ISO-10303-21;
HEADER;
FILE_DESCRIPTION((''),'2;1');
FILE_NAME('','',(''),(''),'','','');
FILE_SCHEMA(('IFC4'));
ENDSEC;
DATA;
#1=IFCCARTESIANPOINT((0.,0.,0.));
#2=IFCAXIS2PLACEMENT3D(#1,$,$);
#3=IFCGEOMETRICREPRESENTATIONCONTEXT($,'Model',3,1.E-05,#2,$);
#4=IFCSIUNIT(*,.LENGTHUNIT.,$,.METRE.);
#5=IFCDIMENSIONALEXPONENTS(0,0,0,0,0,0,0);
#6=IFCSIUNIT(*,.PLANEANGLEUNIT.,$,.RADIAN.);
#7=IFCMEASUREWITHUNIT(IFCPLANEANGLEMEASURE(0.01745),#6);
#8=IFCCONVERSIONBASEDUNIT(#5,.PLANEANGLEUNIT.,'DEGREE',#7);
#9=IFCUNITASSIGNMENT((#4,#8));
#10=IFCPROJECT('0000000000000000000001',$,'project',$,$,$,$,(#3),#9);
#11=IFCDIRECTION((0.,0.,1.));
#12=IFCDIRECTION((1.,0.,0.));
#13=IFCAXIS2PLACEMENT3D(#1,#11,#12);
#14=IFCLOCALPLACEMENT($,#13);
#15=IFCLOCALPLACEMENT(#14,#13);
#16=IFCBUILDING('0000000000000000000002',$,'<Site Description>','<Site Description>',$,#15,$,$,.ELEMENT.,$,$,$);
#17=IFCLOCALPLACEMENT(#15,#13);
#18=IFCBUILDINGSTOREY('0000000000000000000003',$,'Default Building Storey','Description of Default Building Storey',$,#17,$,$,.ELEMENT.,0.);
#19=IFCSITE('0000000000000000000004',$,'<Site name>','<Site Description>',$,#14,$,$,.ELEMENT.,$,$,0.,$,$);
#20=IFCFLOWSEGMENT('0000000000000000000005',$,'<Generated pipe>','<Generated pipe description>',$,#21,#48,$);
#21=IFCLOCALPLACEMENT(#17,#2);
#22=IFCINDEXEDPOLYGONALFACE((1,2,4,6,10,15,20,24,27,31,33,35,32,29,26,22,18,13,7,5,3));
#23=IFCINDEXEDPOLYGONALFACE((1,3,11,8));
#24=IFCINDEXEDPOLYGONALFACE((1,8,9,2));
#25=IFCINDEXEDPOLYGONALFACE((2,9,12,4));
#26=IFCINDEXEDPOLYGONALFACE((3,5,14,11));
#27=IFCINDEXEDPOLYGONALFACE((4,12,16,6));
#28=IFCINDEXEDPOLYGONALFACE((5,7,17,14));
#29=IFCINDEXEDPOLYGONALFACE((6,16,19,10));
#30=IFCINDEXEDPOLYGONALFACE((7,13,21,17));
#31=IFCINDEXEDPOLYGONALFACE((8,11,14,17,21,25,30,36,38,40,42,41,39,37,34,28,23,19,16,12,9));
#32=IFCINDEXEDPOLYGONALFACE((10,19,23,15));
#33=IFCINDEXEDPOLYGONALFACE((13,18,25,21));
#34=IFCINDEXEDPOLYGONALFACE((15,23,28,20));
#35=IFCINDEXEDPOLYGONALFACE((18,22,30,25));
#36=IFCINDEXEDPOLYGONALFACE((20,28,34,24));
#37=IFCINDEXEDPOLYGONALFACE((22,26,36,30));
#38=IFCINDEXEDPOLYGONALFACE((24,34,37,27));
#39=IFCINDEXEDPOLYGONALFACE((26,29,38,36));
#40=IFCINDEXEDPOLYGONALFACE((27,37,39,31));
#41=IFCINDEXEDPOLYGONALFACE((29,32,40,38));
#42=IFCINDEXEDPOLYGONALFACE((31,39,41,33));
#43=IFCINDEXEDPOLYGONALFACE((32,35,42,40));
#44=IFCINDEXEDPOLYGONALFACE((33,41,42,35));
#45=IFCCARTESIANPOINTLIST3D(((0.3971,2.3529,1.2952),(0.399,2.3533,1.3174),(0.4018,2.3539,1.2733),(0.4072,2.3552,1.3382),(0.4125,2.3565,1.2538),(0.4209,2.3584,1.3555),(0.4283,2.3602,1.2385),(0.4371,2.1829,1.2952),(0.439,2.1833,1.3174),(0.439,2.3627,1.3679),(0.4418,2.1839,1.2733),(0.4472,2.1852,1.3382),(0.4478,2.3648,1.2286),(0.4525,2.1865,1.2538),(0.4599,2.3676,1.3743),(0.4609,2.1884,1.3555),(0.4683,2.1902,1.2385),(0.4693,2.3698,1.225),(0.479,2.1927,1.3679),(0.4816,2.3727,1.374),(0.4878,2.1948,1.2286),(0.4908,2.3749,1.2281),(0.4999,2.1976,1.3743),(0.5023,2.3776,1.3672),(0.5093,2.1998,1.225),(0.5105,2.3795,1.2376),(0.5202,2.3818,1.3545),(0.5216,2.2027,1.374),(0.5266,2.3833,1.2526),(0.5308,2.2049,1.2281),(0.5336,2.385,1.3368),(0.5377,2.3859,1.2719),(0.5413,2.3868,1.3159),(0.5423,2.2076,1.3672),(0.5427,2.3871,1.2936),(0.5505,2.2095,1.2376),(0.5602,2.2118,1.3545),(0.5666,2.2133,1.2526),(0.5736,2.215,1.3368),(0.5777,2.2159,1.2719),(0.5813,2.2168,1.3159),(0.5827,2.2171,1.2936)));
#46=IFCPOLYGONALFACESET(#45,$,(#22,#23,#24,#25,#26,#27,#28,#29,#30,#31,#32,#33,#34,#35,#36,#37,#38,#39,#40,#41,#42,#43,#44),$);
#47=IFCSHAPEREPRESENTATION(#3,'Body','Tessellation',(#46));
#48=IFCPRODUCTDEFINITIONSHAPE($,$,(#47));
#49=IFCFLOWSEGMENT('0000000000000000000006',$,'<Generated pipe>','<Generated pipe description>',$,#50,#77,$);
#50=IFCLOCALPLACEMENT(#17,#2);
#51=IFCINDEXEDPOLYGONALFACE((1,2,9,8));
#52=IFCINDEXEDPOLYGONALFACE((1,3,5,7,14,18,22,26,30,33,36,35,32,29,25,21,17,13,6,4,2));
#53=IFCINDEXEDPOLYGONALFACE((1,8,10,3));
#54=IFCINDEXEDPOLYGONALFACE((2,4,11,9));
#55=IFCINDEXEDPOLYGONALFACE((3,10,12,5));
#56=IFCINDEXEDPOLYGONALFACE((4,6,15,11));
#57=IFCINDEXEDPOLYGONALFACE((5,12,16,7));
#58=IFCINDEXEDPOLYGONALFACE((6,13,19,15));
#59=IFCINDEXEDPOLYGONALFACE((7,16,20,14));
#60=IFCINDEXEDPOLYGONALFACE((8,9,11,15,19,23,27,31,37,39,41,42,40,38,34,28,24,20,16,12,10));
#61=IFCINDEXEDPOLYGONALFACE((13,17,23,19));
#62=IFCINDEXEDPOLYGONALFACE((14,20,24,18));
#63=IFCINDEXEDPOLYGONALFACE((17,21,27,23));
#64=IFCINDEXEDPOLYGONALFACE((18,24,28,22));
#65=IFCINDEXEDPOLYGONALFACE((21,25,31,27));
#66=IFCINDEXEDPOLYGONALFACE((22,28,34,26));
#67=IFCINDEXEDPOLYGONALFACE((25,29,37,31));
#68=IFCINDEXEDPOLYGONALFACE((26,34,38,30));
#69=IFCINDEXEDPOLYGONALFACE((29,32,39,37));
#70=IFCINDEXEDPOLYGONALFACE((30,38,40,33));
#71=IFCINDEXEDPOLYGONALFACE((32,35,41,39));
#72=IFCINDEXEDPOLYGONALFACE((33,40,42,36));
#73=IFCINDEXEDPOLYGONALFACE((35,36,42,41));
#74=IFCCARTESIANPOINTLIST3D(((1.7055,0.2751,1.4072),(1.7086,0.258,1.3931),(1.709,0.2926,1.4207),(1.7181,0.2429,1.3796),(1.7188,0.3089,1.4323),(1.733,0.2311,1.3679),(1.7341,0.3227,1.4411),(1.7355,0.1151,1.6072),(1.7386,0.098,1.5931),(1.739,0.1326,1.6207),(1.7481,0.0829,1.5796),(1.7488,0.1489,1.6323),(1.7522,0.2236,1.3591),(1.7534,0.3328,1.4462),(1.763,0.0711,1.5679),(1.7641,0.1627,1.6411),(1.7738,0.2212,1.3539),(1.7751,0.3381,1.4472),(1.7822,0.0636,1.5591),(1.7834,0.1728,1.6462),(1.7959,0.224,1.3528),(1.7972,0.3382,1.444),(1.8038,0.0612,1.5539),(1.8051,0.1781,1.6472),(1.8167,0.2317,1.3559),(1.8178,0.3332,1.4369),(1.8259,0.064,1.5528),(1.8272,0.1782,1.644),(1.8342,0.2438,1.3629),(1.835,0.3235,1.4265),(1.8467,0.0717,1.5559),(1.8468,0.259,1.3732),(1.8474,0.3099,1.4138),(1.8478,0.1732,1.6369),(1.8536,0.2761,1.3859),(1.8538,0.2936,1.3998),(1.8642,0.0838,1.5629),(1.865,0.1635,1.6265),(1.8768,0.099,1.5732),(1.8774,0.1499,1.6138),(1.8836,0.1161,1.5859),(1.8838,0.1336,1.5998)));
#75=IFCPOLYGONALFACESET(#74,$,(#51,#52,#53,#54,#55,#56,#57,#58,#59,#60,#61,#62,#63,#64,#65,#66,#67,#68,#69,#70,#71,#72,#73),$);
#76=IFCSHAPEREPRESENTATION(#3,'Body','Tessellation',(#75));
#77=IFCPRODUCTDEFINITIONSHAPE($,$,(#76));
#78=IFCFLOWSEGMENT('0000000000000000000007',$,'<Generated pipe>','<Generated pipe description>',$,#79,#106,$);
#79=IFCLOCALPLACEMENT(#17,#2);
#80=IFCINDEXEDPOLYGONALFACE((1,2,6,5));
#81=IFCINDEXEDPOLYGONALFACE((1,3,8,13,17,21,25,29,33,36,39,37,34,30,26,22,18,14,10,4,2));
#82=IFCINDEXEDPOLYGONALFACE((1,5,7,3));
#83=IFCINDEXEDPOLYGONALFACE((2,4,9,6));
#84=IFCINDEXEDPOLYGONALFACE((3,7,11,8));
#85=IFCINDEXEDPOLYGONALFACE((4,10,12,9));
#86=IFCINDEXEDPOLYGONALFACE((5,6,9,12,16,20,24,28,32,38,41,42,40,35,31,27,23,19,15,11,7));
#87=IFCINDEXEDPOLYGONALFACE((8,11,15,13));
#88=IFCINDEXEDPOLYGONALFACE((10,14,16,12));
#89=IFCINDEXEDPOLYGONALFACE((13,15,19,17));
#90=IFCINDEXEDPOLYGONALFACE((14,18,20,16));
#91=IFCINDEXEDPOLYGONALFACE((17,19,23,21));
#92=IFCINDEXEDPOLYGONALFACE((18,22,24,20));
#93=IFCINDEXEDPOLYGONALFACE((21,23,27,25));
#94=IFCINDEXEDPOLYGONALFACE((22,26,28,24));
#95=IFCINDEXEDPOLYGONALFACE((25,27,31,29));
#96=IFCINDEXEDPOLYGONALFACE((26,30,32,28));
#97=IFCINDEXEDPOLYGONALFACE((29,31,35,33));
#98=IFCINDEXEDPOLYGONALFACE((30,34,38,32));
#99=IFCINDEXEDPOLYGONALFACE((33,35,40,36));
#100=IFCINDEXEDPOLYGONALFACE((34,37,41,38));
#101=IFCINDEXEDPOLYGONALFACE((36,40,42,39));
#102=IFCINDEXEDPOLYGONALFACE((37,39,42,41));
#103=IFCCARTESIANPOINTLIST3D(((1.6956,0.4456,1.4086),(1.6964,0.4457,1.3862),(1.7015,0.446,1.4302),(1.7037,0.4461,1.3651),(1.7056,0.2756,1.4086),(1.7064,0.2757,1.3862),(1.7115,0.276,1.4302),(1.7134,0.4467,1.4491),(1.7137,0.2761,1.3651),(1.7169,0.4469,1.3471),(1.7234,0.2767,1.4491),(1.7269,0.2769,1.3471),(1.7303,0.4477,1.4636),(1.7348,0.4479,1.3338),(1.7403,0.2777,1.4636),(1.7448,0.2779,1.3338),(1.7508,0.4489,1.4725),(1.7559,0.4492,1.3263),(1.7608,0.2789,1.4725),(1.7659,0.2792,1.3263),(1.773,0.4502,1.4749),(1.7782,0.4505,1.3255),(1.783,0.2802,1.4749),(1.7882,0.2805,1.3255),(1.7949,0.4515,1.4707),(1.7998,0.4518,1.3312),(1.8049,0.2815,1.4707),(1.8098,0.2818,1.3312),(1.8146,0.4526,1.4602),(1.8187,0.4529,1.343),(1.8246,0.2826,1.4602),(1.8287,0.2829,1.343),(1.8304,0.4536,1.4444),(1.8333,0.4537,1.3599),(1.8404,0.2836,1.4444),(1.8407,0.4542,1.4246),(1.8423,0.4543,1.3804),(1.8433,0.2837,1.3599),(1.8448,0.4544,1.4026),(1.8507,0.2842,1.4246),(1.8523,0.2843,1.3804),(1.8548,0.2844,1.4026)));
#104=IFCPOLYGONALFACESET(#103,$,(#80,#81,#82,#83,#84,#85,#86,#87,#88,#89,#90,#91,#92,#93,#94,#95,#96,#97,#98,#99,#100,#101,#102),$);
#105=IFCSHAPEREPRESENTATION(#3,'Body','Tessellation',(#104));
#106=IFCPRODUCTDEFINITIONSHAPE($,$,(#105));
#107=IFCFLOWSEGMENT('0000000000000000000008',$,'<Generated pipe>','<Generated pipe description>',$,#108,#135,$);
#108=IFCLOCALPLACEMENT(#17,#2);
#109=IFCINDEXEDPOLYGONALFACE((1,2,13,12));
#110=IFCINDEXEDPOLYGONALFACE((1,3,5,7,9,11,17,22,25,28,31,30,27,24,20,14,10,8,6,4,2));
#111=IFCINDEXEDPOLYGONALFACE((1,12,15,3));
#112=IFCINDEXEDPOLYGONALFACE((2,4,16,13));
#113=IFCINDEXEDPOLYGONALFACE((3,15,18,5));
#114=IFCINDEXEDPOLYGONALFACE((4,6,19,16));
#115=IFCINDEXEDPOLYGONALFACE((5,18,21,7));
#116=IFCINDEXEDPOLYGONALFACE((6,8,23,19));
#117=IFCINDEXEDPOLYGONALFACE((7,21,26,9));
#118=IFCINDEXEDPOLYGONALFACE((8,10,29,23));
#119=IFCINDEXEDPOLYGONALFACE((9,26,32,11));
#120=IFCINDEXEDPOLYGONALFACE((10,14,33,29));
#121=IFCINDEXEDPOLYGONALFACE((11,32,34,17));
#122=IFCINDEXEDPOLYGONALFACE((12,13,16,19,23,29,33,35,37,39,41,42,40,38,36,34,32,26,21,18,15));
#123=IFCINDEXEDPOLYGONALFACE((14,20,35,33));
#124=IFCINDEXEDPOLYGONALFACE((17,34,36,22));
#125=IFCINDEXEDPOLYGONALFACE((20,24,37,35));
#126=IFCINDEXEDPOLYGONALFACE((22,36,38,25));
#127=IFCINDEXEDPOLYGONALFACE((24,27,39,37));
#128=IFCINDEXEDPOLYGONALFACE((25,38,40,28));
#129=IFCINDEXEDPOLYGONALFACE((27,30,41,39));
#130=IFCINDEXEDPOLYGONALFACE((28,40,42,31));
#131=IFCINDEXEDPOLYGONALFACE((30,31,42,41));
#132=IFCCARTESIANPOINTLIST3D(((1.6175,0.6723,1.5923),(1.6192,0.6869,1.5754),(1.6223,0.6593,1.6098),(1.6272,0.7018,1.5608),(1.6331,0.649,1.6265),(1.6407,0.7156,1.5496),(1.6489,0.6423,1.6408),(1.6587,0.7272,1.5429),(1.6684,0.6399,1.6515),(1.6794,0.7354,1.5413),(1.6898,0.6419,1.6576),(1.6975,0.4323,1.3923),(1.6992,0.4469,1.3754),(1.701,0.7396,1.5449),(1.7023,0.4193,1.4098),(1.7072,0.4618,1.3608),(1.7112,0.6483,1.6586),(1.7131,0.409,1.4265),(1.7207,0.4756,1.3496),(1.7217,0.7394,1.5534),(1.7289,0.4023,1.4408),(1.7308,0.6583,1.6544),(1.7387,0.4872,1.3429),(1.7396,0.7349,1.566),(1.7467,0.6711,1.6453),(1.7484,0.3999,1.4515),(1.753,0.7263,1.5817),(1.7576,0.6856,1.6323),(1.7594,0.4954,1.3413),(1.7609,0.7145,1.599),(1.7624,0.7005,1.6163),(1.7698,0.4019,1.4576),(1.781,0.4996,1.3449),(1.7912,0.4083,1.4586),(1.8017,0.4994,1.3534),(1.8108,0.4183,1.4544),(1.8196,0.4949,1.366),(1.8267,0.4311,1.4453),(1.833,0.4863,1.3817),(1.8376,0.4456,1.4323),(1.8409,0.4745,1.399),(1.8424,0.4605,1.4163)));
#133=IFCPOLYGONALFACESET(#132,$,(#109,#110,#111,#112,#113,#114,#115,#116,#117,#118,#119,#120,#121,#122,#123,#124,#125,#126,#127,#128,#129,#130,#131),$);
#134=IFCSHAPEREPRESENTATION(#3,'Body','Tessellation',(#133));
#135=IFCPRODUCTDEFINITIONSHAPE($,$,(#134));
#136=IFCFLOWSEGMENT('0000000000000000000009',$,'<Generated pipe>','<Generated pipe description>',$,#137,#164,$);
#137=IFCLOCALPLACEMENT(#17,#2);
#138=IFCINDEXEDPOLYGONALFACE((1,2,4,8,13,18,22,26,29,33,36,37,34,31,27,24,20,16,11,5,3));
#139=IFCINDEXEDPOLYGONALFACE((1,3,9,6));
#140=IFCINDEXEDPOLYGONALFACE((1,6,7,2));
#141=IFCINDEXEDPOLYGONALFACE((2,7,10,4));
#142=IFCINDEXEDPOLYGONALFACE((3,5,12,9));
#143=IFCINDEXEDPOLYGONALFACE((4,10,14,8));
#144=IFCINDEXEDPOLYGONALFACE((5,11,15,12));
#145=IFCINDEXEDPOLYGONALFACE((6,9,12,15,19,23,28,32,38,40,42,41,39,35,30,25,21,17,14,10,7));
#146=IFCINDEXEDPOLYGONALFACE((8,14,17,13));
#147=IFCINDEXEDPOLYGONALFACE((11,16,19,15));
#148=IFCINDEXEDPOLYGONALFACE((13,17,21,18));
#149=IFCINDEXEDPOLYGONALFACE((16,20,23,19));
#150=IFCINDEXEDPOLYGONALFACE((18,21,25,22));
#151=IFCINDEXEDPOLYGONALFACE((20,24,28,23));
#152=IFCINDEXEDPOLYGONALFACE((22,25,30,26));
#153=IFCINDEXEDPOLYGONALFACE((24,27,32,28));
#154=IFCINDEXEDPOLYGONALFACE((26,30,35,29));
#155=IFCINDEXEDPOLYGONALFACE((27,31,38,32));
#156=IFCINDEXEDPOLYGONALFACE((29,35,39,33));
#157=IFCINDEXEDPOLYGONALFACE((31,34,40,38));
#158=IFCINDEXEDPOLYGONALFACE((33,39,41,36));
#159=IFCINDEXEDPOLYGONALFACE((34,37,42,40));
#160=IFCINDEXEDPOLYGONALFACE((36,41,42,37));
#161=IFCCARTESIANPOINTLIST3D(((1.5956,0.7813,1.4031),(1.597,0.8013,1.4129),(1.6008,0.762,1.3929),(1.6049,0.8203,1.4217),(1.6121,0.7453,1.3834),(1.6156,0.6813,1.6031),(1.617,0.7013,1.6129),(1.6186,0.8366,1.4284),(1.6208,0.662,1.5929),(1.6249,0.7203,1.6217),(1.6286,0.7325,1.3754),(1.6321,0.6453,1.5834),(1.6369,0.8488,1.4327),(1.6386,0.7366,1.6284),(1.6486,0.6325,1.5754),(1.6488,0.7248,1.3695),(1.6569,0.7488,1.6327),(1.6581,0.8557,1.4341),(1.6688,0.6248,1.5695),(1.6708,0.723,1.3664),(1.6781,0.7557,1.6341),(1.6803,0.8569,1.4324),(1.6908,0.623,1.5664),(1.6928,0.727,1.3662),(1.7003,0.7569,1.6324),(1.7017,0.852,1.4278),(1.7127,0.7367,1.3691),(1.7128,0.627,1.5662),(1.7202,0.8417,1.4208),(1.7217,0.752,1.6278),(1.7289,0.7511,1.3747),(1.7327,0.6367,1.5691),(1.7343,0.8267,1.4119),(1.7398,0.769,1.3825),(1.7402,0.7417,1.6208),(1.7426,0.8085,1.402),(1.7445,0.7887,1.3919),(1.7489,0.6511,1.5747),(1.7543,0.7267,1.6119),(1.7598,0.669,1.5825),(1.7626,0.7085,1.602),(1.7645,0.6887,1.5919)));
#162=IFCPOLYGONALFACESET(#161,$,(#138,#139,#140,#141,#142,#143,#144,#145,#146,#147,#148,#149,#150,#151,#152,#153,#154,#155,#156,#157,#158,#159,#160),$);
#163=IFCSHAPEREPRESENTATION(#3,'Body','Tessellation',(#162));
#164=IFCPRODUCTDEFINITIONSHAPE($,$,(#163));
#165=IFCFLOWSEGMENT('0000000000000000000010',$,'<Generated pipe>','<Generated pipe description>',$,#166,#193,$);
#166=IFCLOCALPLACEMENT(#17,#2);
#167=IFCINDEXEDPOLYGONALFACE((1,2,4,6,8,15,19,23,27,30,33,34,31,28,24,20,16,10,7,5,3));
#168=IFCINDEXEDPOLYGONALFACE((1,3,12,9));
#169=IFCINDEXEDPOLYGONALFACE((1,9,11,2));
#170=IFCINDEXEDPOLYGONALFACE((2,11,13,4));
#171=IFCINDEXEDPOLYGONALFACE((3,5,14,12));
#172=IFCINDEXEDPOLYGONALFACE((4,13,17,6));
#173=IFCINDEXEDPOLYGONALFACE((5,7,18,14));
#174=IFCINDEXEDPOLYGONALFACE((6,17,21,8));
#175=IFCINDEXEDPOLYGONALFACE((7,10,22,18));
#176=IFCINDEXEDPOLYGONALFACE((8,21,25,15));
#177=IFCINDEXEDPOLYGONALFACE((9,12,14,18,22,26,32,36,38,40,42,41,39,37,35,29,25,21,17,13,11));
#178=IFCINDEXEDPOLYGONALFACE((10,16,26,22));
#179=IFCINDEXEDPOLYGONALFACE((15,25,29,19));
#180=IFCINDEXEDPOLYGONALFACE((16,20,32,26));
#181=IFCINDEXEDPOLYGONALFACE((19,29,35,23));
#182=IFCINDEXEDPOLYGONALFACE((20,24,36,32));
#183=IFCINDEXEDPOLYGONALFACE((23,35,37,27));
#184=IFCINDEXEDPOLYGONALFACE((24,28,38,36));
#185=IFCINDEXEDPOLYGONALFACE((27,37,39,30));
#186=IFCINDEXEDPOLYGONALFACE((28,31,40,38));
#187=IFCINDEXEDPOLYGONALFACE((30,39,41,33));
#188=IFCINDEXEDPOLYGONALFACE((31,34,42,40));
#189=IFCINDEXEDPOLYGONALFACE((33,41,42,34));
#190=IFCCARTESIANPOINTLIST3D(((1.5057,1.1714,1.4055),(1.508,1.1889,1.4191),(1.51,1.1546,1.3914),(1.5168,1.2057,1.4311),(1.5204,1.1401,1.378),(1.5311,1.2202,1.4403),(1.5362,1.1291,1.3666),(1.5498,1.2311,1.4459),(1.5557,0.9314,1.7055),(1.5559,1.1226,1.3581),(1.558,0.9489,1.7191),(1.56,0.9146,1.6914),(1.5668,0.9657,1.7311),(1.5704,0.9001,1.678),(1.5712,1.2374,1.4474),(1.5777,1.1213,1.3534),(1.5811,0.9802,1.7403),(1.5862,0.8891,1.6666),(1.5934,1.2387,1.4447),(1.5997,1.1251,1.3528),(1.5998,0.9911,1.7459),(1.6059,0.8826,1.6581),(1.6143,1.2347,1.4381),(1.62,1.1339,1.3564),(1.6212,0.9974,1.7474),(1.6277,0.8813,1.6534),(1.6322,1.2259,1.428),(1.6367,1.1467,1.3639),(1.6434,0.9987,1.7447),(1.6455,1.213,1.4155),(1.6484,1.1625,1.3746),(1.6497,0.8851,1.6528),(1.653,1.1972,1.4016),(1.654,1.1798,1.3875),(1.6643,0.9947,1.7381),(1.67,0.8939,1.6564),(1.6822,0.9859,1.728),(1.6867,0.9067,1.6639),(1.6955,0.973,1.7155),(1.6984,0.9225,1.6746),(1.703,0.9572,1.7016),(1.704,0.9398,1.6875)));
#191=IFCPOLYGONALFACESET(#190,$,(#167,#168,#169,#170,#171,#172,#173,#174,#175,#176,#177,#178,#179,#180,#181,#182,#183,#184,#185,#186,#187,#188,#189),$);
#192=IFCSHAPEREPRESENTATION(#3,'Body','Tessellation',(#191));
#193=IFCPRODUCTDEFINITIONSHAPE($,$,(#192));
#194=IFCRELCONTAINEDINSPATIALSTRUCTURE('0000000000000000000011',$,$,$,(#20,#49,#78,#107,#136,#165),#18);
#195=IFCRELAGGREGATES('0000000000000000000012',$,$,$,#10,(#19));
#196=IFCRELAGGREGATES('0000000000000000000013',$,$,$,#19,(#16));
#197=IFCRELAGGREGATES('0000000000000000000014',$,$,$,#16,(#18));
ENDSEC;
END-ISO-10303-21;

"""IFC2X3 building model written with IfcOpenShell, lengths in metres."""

from ifc_helpers import new_model, entity, si_unit, converted_unit, frame, origin, origin_with_axes, origin_2d_with_axis, place, context, project, spatial, circle, extrude, element, save


model = new_model("IFC2X3")

# Units and contexts
model_context = context("Model", 3, precision=1e-05, world=origin())
ifc_project = project(units=[si_unit("LENGTHUNIT", "METRE"), converted_unit("PLANEANGLEUNIT", "DEGREE", entity("IfcPlaneAngleMeasure", 0.01745), si_unit("PLANEANGLEUNIT", "RADIAN"), dimensions=[0, 0, 0, 0, 0, 0, 0])], contexts=[model_context])

# Site, building, storey
site_placement = place(None, origin_with_axes())
site = spatial("IfcSite", under=ifc_project, at=site_placement, Name="<Site name>", Description="<Site Description>", CompositionType="ELEMENT", RefElevation=0.0)
building_placement = place(site_placement, origin_with_axes())
building = spatial("IfcBuilding", under=site, at=building_placement, Name="<Site Description>", Description="<Site Description>", CompositionType="ELEMENT")
storey_placement = place(building_placement, origin_with_axes())
storey = spatial("IfcBuildingStorey", under=building, at=storey_placement, Name="Default Building Storey", Description="Description of Default Building Storey", CompositionType="ELEMENT", Elevation=0.0)

# Flow segments
flow_segment_1_placement = place(storey_placement, frame((0.51, 2.2, 1.3), z_axis=(-0.229039, 0.973417, 0.0), x_axis=(0.847957, 0.199519, 0.491081)))
element("IfcFlowSegment", 1, at=flow_segment_1_placement, inside=storey, Name="<Generated pipe>", Description="<Generated pipe description>", context=model_context, shape_type="SweptSolid", body=[
    extrude(circle(Radius=0.075, at=origin_2d_with_axis()), origin_with_axes(), (0.0, 0.0, 1.0), 0.1746),
])
flow_segment_2_placement = place(storey_placement, frame((1.81, 0.12, 1.6), z_axis=(-0.116335, 0.620453, -0.775567), x_axis=(0.504113, 0.709696, 0.49214)))
element("IfcFlowSegment", 2, at=flow_segment_2_placement, inside=storey, Name="<Generated pipe>", Description="<Generated pipe description>", context=model_context, shape_type="SweptSolid", body=[
    extrude(circle(Radius=0.075, at=origin_2d_with_axis()), origin_with_axes(), (0.0, 0.0, 1.0), 0.2579),
])
flow_segment_3_placement = place(storey_placement, frame((1.78, 0.28, 1.4), z_axis=(-0.058722, 0.998274, 0.0), x_axis=(0.33209, 0.019535, 0.943045)))
element("IfcFlowSegment", 3, at=flow_segment_3_placement, inside=storey, Name="<Generated pipe>", Description="<Generated pipe description>", context=model_context, shape_type="SweptSolid", body=[
    extrude(circle(Radius=0.075, at=origin_2d_with_axis()), origin_with_axes(), (0.0, 0.0, 1.0), 0.1703),
])
flow_segment_4_placement = place(storey_placement, frame((1.77, 0.45, 1.4), z_axis=(-0.248069, 0.744208, 0.620174), x_axis=(0.96583, 0.140394, 0.217859)))
element("IfcFlowSegment", 4, at=flow_segment_4_placement, inside=storey, Name="<Generated pipe>", Description="<Generated pipe description>", context=model_context, shape_type="SweptSolid", body=[
    extrude(circle(Radius=0.075, at=origin_2d_with_axis()), origin_with_axes(), (0.0, 0.0, 1.0), 0.3225),
])
flow_segment_5_placement = place(storey_placement, frame((1.69, 0.69, 1.6), z_axis=(-0.089087, 0.445435, -0.890871), x_axis=(0.669489, 0.689018, 0.27756)))
element("IfcFlowSegment", 5, at=flow_segment_5_placement, inside=storey, Name="<Generated pipe>", Description="<Generated pipe description>", context=model_context, shape_type="SweptSolid", body=[
    extrude(circle(Radius=0.075, at=origin_2d_with_axis()), origin_with_axes(), (0.0, 0.0, 1.0), 0.2245),
])
flow_segment_6_placement = place(storey_placement, frame((1.63, 0.94, 1.7), z_axis=(-0.129056, 0.619471, -0.774339), x_axis=(0.457661, 0.72994, 0.507675)))
element("IfcFlowSegment", 6, at=flow_segment_6_placement, inside=storey, Name="<Generated pipe>", Description="<Generated pipe description>", context=model_context, shape_type="SweptSolid", body=[
    extrude(circle(Radius=0.075, at=origin_2d_with_axis()), origin_with_axes(), (0.0, 0.0, 1.0), 0.3874),
])

save(model, "model.ifc")
